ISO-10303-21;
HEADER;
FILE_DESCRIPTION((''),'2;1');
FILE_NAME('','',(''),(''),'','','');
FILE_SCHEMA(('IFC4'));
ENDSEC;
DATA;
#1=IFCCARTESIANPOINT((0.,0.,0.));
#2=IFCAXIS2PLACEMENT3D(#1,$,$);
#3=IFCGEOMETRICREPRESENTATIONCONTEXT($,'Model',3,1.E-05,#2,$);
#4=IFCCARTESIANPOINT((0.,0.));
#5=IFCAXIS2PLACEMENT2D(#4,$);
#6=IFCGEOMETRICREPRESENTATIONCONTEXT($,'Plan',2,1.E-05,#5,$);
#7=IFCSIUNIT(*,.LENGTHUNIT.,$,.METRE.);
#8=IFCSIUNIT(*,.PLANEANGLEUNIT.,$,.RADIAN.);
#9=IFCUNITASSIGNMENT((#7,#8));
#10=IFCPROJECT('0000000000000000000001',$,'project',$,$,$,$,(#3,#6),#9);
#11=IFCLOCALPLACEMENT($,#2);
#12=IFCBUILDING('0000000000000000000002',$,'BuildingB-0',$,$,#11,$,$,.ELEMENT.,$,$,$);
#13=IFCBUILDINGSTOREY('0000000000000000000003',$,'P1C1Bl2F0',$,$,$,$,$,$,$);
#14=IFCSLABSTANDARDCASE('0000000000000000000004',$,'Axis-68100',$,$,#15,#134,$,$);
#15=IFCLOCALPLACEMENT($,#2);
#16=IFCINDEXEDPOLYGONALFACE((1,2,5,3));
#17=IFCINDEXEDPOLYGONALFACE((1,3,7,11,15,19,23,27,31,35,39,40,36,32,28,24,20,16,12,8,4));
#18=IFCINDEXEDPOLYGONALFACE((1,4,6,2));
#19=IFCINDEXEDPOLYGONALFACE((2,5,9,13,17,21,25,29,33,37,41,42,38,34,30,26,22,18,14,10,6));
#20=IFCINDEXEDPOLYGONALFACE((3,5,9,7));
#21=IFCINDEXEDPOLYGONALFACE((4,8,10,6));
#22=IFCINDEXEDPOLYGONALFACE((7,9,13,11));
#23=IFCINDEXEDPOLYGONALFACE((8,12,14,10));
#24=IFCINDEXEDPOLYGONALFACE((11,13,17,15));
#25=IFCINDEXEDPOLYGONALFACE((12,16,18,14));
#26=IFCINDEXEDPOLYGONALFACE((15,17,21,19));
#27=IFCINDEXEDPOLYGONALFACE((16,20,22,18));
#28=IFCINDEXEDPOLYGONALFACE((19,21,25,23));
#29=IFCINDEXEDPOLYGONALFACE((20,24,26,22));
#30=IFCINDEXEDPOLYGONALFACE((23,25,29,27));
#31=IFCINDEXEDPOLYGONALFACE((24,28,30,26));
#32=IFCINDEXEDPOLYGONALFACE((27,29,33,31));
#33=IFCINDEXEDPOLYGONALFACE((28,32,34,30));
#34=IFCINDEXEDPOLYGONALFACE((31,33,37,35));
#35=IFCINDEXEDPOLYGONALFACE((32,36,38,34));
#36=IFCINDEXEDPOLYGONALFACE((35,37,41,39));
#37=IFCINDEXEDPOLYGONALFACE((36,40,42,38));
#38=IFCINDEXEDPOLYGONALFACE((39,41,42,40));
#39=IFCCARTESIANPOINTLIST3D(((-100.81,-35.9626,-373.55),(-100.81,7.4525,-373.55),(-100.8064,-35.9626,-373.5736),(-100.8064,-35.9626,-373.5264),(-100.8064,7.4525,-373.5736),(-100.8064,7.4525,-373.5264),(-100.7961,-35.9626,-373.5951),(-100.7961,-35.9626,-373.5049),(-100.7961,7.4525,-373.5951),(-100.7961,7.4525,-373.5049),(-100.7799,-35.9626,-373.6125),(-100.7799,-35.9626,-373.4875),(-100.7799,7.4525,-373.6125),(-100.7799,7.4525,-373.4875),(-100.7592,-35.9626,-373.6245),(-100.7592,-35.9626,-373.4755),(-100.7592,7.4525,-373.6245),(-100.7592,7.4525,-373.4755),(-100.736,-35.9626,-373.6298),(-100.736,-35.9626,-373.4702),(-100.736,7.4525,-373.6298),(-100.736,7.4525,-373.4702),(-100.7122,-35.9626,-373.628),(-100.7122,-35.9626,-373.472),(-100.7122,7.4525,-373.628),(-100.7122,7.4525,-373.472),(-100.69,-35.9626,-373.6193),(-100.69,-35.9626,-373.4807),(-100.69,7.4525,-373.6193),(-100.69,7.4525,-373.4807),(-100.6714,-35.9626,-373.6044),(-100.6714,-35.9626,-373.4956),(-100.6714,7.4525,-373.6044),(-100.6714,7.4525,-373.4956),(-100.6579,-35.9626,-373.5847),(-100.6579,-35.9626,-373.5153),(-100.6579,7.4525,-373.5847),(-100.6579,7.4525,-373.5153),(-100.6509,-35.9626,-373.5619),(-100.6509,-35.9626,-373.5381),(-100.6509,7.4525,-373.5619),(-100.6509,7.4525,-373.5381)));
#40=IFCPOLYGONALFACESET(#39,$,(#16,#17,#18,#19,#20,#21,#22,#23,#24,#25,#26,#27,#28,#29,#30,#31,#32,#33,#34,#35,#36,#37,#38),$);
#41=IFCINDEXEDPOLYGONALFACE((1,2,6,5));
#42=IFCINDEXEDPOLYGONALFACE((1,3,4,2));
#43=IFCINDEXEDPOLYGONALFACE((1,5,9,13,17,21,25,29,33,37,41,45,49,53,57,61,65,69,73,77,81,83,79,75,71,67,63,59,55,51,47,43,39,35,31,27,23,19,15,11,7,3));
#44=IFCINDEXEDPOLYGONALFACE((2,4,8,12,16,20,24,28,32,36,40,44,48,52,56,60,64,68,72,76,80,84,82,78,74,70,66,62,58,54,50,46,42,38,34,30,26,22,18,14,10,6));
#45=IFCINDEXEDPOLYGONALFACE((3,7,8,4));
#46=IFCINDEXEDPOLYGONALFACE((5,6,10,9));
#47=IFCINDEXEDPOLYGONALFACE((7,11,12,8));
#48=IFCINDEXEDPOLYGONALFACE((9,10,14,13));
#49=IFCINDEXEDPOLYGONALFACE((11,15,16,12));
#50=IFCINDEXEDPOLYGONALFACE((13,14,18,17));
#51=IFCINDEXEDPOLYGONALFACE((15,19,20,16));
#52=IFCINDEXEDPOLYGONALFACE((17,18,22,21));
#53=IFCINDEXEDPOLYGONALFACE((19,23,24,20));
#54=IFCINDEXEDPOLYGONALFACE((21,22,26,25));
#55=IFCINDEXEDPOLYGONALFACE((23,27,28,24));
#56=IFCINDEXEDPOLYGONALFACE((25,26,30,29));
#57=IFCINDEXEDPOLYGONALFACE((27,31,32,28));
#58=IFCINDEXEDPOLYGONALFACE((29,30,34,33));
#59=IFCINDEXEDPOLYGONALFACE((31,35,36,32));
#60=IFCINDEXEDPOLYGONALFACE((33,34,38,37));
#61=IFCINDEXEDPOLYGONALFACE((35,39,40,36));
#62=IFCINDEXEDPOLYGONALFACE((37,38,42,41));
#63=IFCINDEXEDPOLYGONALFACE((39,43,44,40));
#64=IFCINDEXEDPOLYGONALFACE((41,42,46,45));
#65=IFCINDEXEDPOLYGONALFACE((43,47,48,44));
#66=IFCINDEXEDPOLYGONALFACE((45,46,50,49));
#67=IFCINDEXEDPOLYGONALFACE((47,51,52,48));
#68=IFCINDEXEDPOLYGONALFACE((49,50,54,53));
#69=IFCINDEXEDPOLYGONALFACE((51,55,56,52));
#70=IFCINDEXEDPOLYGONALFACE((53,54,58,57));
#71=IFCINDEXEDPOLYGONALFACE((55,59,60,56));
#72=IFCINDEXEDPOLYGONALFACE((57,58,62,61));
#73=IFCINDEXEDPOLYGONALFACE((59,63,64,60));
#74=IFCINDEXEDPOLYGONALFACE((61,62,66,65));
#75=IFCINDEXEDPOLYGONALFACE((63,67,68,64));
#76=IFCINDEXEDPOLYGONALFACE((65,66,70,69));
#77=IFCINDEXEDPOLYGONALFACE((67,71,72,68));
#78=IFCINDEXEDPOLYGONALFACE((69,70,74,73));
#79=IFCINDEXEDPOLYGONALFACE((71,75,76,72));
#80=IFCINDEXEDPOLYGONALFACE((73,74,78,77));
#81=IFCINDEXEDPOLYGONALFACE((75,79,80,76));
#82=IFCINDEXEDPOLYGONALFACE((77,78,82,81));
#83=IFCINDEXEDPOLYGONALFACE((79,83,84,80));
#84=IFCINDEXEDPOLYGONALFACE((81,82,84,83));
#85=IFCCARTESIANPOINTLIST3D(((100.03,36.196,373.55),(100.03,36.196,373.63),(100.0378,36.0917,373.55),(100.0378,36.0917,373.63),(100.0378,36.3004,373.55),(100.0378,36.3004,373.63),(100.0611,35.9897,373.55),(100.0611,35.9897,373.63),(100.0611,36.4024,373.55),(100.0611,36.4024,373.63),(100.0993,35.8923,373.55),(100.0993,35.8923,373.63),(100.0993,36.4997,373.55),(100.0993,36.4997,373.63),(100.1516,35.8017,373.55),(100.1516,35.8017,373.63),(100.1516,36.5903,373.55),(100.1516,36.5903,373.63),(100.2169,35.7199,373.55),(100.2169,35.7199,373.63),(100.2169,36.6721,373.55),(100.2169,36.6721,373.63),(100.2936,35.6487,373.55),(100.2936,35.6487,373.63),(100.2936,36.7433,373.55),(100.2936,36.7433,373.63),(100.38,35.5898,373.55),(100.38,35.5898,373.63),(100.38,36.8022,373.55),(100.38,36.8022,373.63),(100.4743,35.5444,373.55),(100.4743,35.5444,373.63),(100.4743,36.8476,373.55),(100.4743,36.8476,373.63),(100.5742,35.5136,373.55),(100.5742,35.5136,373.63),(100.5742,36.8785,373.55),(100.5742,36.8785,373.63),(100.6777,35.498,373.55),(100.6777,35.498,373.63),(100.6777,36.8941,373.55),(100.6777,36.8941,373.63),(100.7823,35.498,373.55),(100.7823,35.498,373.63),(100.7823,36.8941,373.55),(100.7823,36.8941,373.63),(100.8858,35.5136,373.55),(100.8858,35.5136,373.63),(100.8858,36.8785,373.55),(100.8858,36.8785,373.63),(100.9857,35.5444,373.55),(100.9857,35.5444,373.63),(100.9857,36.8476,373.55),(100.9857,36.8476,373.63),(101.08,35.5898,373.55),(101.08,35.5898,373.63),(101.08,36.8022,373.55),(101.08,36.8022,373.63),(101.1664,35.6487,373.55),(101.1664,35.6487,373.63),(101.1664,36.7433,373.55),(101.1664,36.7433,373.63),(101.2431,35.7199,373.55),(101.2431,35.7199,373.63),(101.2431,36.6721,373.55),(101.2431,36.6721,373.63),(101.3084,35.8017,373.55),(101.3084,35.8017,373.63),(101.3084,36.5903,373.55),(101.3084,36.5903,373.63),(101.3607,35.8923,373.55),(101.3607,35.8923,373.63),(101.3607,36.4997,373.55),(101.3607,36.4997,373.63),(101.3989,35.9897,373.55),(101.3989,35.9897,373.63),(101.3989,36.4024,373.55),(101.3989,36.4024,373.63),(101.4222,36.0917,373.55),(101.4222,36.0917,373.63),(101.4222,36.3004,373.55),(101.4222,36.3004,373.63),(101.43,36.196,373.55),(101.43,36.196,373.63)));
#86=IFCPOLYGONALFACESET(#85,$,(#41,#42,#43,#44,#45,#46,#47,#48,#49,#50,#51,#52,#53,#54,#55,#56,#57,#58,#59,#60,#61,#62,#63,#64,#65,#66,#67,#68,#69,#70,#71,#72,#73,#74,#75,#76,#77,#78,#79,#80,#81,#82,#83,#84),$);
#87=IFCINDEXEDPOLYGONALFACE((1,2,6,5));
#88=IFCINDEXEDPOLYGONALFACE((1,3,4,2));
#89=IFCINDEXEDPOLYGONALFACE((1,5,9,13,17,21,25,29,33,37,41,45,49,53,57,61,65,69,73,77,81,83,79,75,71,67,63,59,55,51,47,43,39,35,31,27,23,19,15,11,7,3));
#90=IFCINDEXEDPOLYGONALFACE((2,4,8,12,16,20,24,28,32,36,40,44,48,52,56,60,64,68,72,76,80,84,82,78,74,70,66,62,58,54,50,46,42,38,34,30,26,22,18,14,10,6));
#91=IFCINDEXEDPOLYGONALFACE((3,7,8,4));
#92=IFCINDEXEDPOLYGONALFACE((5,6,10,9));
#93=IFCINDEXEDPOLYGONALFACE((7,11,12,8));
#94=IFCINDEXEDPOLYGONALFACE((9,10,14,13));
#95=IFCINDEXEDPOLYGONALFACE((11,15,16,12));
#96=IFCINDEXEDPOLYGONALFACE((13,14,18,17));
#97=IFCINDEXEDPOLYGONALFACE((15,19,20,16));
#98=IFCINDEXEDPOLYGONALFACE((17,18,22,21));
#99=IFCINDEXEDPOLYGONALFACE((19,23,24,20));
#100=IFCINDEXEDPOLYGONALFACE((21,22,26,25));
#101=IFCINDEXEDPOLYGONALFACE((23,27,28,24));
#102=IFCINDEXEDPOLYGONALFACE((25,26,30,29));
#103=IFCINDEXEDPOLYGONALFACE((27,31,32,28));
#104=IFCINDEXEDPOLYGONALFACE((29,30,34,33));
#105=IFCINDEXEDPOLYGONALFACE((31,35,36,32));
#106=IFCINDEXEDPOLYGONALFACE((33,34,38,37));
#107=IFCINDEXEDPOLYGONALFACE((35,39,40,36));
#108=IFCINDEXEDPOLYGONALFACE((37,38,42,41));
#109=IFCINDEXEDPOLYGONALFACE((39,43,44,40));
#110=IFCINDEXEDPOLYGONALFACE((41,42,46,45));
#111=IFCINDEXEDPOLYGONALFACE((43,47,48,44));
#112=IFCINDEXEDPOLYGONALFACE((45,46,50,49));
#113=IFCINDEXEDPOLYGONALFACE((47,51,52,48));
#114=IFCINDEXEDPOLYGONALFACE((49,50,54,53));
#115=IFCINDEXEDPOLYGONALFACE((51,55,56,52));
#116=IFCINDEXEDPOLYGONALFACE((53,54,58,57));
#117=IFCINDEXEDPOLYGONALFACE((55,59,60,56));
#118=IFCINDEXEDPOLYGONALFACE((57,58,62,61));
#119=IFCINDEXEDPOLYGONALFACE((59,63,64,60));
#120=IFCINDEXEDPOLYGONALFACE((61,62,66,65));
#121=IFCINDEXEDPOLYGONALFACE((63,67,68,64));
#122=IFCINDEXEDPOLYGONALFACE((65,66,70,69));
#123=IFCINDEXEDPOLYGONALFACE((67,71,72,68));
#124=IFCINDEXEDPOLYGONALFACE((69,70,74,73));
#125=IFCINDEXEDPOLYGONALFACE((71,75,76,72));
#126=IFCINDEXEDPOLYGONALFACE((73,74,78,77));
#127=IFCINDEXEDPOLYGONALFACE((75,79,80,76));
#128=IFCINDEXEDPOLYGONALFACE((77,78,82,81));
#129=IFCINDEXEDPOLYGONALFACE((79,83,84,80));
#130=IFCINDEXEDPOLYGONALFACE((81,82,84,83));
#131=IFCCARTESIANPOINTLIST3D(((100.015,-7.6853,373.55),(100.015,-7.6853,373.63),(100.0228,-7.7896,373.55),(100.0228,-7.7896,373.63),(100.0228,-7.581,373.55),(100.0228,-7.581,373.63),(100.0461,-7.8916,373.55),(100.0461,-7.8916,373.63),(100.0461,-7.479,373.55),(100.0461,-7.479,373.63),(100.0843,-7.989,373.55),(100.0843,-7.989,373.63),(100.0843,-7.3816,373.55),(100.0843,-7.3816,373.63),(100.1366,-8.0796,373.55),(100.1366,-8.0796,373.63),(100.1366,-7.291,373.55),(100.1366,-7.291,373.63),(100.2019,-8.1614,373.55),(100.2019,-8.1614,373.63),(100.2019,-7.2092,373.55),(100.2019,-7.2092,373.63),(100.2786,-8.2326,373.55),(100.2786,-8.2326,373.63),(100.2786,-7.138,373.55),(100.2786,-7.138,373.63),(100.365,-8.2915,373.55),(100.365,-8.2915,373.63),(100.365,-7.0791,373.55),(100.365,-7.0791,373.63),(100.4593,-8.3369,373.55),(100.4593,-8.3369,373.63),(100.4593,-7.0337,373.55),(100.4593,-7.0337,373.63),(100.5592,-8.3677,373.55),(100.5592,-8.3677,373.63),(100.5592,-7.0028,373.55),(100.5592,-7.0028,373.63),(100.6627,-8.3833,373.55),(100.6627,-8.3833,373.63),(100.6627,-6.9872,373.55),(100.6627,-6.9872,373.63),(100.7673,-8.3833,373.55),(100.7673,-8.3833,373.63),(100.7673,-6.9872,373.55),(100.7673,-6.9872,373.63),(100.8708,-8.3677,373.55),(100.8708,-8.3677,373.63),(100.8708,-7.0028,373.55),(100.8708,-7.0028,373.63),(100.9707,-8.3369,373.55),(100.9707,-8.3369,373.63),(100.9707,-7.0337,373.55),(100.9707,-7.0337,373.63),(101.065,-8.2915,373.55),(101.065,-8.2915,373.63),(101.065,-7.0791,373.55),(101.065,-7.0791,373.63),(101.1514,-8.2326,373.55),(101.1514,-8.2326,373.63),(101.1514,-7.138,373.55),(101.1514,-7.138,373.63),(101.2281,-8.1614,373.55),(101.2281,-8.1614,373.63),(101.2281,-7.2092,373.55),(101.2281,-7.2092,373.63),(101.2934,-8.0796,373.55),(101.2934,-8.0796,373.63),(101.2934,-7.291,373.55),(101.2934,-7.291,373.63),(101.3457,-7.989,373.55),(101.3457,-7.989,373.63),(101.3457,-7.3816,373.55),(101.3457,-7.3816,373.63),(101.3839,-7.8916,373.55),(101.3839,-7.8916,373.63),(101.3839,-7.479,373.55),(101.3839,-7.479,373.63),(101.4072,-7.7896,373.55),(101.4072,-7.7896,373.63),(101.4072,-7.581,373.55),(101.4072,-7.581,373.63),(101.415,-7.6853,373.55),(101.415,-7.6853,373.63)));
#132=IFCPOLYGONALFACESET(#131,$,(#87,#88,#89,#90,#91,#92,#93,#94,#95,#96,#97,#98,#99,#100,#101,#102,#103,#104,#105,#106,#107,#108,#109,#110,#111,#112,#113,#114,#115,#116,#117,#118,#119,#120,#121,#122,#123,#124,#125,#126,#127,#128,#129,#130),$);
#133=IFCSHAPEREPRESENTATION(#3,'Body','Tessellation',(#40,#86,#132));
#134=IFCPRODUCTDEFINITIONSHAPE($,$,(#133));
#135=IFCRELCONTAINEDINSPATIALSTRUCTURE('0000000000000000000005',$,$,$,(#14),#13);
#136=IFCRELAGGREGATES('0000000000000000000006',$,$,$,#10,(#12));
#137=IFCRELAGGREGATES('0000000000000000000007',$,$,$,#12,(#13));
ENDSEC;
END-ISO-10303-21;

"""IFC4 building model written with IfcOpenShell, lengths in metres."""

from ifc_helpers import new_model, entity, si_unit, frame, origin, origin_2d, place, context, project, spatial, circle, extrude, element, save


model = new_model("IFC4")

# Units and contexts
model_context = context("Model", 3, precision=1e-05, world=origin())
plan_context = context("Plan", 2, precision=1e-05, world=origin_2d())
ifc_project = project(units=[si_unit("LENGTHUNIT", "METRE"), si_unit("PLANEANGLEUNIT", "RADIAN")], contexts=[model_context, plan_context])

# Building, storey
building_placement = place(None, origin())
building = spatial("IfcBuilding", under=ifc_project, at=building_placement, Name="BuildingB-0", CompositionType="ELEMENT")
storey = spatial("IfcBuildingStorey", under=building, Name="P1C1Bl2F0")

# Slab
element("IfcSlabStandardCase", 1, inside=storey, Name="Axis-68100", context=model_context, shape_type="AdvancedSweptSolid", body=[
    entity("IfcSurfaceCurveSweptAreaSolid", entity("IfcCircleProfileDef", "AREA", None, None, 0.08), None, entity("IfcPolyline", [entity("IfcCartesianPoint", [100.73, 35.9626, 373.55]), entity("IfcCartesianPoint", [100.73, -7.4525, 373.55])]), None, None, entity("IfcPlane", entity("IfcAxis2Placement3D", entity("IfcCartesianPoint", [100.73, 35.9626, 373.55]), entity("IfcDirection", [0.0, 0.0, 1.0]), entity("IfcDirection", [1.0, 0.0, 0.0])))),
    extrude(circle(Radius=0.7), frame((100.73, 36.196, 373.55)), (0.0, 0.0, 1.0), 0.08),
    extrude(circle(Radius=0.7), frame((100.715, -7.6853, 373.55)), (0.0, 0.0, 1.0), 0.08),
])

save(model, "model.ifc")
